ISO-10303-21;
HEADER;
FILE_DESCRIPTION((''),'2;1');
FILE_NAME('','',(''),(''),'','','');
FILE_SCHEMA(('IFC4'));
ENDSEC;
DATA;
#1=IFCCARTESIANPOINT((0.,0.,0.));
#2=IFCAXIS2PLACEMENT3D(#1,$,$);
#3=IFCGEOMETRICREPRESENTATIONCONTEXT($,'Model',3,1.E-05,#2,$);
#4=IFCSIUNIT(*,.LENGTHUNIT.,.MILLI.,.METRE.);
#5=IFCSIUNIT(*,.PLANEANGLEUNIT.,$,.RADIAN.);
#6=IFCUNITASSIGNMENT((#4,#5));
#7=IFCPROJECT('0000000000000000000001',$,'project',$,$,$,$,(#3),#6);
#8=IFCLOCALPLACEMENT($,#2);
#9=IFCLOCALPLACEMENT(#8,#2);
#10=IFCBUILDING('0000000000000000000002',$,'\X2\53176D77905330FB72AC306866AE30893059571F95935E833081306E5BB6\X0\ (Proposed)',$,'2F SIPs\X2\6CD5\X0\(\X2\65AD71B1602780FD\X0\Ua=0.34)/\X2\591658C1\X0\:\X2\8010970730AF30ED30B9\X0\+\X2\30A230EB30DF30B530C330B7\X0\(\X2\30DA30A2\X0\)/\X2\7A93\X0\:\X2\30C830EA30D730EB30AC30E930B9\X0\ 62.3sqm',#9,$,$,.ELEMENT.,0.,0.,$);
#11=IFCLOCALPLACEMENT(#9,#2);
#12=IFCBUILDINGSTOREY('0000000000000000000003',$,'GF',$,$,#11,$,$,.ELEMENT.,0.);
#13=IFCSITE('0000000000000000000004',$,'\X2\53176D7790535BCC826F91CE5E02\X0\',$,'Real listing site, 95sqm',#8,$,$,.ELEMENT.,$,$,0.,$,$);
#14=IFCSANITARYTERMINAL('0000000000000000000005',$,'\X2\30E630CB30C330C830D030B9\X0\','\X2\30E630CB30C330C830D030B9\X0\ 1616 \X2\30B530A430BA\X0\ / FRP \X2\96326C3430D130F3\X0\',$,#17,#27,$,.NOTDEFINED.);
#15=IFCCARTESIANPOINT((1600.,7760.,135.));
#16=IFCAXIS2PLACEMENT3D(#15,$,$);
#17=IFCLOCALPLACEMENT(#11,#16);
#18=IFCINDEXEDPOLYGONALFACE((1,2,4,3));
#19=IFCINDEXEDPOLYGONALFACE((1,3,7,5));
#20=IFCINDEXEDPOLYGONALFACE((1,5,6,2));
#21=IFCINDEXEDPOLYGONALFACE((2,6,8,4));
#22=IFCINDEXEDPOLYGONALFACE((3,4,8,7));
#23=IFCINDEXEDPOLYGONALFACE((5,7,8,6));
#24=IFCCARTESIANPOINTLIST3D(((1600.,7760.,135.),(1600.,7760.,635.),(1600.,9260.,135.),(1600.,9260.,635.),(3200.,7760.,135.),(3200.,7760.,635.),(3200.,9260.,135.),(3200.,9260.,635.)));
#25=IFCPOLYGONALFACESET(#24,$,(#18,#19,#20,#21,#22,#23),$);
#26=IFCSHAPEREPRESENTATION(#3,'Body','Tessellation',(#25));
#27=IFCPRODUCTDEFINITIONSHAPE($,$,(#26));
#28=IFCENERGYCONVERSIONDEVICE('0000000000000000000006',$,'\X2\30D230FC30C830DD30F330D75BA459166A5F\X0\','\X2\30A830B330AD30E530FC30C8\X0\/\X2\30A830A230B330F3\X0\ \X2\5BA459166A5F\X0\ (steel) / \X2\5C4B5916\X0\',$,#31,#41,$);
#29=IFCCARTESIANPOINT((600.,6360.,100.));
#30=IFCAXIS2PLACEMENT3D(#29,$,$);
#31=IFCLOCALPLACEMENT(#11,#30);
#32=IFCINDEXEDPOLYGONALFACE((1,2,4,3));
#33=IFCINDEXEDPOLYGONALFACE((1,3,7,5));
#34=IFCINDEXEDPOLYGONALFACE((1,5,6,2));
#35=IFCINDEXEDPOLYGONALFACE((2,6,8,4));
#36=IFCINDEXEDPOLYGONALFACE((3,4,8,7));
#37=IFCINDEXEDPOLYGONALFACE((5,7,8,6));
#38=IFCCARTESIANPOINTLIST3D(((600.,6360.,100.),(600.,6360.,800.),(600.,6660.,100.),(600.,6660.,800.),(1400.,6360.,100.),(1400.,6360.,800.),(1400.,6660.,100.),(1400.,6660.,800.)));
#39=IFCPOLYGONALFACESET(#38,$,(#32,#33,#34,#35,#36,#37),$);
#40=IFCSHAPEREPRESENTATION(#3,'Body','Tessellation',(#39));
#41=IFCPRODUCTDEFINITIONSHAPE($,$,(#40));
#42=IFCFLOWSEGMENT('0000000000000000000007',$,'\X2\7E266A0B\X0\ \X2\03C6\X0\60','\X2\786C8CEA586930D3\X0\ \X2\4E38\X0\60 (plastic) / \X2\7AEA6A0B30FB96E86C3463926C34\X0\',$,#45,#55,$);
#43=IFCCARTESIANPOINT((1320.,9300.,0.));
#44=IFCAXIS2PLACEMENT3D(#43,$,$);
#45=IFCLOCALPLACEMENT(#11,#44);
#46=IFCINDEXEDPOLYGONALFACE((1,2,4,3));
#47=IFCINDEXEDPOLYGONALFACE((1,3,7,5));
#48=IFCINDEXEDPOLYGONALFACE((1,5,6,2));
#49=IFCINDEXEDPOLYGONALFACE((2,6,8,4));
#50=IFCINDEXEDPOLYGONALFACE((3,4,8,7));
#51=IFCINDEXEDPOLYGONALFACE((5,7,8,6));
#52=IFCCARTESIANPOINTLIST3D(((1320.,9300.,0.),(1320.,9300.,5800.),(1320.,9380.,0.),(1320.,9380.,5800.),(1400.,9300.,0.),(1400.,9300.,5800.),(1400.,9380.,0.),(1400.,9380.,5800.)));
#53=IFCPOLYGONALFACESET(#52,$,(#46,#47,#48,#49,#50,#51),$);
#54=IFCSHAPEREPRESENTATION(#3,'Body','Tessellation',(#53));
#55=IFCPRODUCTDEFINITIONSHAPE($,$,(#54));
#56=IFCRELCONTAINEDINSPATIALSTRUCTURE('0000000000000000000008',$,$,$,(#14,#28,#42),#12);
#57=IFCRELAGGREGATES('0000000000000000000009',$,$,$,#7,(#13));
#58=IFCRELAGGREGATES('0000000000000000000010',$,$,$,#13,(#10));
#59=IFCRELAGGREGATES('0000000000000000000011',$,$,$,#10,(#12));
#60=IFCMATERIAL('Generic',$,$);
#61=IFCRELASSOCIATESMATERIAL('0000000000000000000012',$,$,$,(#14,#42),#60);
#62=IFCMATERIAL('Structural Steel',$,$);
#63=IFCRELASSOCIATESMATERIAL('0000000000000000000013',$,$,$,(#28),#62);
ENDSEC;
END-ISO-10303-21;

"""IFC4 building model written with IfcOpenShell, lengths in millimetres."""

from ifc_helpers import new_model, si_unit, frame, frame_2d, origin, place, context, project, spatial, rectangle, extrude, material, element, save


model = new_model("IFC4")

# Units and contexts
model_context = context("Model", 3, precision=1e-05, world=origin())
ifc_project = project(units=[si_unit("LENGTHUNIT", "METRE", prefix="MILLI"), si_unit("PLANEANGLEUNIT", "RADIAN")], contexts=[model_context])

# Site, building, storey
site_placement = place(None, origin())
site = spatial("IfcSite", under=ifc_project, at=site_placement, Name="北海道富良野市", ObjectType="Real listing site, 95sqm", CompositionType="ELEMENT", RefElevation=0.0)
building_placement = place(site_placement, origin())
building = spatial("IfcBuilding", under=site, at=building_placement, Name="北海道・犬と暮らす土間広めの家 (Proposed)", ObjectType="2F SIPs法(断熱性能Ua=0.34)/外壁:耐震クロス+アルミサッシ(ペア)/窓:トリプルガラス 62.3sqm", CompositionType="ELEMENT", ElevationOfRefHeight=0.0, ElevationOfTerrain=0.0)
storey_placement = place(building_placement, origin())
storey = spatial("IfcBuildingStorey", under=building, at=storey_placement, Name="GF", CompositionType="ELEMENT", Elevation=0.0)

# Shared definitions
ifc_material_1 = material(Name="Generic")

# Sanitary terminal
sanitary_terminal_placement = place(storey_placement, frame((1600.0, 7760.0, 135.0)))
element("IfcSanitaryTerminal", 1, at=sanitary_terminal_placement, inside=storey, material=ifc_material_1, Name="ユニットバス", Description="ユニットバス 1616 サイズ / FRP 防水パン", PredefinedType="NOTDEFINED", context=model_context, shape_type="SweptSolid", body=[
    extrude(rectangle(XDim=1600.0, YDim=1500.0, at=frame_2d((800.0, 750.0))), frame((1600.0, 7760.0, 135.0)), (0.0, 0.0, 1.0), 500.0),
])

# Energy conversion device
ifc_material_2 = material(Name="Structural Steel")
energy_conversion_device_placement = place(storey_placement, frame((600.0, 6360.0, 100.0)))
element("IfcEnergyConversionDevice", 2, at=energy_conversion_device_placement, inside=storey, material=ifc_material_2, Name="ヒートポンプ室外機", Description="エコキュート/エアコン 室外機 (steel) / 屋外", context=model_context, shape_type="SweptSolid", body=[
    extrude(rectangle(XDim=800.0, YDim=300.0, at=frame_2d((400.0, 150.0))), frame((600.0, 6360.0, 100.0)), (0.0, 0.0, 1.0), 700.0),
])

# Flow segment
flow_segment_placement = place(storey_placement, frame((1320.0, 9300.0, 0.0)))
element("IfcFlowSegment", 3, at=flow_segment_placement, inside=storey, material=ifc_material_1, Name="縦樋 φ60", Description="硬質塩ビ 丸60 (plastic) / 竪樋・雨水排水", context=model_context, shape_type="SweptSolid", body=[
    extrude(rectangle(XDim=80.0, YDim=80.0, at=frame_2d((40.0, 40.0))), frame((1320.0, 9300.0, 0.0)), (0.0, 0.0, 1.0), 5800.0),
])

save(model, "model.ifc")
